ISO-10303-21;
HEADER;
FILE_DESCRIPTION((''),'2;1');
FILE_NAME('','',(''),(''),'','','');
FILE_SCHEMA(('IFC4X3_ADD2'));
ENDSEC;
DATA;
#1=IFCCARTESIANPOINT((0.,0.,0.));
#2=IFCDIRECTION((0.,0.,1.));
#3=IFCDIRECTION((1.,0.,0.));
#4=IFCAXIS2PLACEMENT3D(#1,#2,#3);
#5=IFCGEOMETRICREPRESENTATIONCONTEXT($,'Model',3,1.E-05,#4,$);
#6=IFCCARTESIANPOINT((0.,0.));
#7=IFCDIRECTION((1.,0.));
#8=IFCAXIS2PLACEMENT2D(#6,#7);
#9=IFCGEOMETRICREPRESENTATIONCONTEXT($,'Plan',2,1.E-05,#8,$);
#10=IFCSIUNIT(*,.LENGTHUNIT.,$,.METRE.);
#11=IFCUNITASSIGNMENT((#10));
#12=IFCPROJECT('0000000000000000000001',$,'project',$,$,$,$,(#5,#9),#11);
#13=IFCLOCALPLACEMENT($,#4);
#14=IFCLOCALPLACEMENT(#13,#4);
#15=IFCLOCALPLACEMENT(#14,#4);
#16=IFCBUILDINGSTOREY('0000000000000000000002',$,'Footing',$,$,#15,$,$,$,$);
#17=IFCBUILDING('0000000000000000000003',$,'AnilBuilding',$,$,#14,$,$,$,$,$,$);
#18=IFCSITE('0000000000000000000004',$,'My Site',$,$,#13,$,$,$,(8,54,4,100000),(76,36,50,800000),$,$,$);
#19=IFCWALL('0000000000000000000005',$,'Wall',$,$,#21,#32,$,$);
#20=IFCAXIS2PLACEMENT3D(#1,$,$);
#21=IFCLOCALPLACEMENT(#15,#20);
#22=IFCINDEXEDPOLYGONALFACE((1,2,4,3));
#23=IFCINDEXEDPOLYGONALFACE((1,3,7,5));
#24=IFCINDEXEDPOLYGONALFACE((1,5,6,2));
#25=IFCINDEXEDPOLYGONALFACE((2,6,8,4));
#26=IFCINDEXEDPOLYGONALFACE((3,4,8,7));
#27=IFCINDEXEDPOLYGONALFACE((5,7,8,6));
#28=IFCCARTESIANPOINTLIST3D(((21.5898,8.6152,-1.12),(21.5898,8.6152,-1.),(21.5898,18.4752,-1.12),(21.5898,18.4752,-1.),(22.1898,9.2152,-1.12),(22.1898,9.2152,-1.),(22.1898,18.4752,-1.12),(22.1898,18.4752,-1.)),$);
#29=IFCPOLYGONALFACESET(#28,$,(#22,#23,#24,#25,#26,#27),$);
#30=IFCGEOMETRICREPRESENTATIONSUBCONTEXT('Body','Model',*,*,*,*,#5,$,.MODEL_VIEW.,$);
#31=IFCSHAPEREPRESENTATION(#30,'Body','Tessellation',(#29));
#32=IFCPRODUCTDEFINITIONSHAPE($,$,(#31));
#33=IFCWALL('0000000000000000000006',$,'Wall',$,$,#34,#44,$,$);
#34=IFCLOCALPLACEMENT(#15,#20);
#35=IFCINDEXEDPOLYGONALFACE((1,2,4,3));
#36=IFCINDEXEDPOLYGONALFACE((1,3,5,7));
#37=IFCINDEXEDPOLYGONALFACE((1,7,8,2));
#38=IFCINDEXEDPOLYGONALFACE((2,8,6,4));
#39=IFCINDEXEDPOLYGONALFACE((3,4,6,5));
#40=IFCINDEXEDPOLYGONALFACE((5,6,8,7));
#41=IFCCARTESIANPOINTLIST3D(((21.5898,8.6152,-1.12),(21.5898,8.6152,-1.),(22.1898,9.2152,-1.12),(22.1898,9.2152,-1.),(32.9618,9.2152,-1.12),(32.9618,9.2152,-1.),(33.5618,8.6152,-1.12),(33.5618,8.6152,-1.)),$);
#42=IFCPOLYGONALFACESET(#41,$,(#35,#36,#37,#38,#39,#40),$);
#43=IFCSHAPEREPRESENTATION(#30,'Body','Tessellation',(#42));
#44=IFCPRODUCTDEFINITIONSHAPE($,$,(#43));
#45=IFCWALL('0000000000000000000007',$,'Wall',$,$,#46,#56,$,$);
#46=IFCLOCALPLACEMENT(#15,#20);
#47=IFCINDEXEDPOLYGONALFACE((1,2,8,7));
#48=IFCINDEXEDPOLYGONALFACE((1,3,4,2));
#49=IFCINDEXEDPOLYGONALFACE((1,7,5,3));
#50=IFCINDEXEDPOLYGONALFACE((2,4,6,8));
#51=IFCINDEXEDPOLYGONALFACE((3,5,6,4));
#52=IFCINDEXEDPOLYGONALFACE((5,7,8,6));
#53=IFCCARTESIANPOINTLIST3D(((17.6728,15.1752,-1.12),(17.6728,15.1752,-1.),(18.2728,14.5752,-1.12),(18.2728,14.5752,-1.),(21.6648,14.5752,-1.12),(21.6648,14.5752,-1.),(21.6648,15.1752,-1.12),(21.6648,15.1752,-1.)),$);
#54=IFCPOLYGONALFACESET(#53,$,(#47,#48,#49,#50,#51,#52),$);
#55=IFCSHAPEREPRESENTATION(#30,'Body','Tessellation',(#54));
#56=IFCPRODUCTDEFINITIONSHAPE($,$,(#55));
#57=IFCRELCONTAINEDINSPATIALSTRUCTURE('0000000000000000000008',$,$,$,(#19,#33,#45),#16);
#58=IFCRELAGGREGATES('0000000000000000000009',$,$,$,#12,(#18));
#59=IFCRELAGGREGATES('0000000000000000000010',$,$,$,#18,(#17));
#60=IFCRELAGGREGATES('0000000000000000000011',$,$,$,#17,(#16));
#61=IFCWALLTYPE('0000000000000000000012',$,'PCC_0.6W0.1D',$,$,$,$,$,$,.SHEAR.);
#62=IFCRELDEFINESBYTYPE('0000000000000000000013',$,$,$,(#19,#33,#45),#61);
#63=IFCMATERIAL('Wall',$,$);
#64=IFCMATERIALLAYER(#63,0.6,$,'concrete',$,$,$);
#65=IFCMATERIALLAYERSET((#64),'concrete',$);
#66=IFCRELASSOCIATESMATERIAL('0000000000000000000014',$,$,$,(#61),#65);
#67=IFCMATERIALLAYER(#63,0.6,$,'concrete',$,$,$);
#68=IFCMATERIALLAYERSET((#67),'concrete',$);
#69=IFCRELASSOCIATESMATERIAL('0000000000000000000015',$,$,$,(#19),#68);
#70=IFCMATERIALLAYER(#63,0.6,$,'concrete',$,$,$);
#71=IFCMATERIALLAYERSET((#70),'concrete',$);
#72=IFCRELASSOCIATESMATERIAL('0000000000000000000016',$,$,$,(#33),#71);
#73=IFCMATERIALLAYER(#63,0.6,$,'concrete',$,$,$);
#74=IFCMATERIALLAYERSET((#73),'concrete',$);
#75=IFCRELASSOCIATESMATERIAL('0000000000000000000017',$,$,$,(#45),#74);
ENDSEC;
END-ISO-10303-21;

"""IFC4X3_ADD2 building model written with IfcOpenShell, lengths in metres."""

from ifc_helpers import new_model, si_unit, frame, origin_with_axes, origin_2d_with_axis, place, context, subcontext, project, spatial, line, indexed_curve, outline, extrude, material, layer, layer_set, layer_usage, type_object, element, save


model = new_model("IFC4X3_ADD2")

# Units and contexts
model_context = context("Model", 3, precision=1e-05, world=origin_with_axes())
plan_context = context("Plan", 2, precision=1e-05, world=origin_2d_with_axis())
body_context = subcontext(model_context, "Body", "Model", "MODEL_VIEW")
ifc_project = project(units=[si_unit("LENGTHUNIT", "METRE")], contexts=[model_context, plan_context])

# Site, building, storey
site_placement = place(None, origin_with_axes())
site = spatial("IfcSite", under=ifc_project, at=site_placement, Name="My Site", RefLatitude=(8, 54, 4, 100000), RefLongitude=(76, 36, 50, 800000))
building_placement = place(site_placement, origin_with_axes())
building = spatial("IfcBuilding", under=site, at=building_placement, Name="AnilBuilding")
storey_placement = place(building_placement, origin_with_axes())
storey = spatial("IfcBuildingStorey", under=building, at=storey_placement, Name="Footing")

# Walls
ifc_material_1 = material(Name="Wall")
ifc_layer_1 = layer(ifc_material_1, 0.6, Name="concrete")
ifc_layer_set_1 = layer_set([ifc_layer_1], Name="concrete")
wall_type_1 = type_object("IfcWallType", Name="PCC_0.6W0.1D", PredefinedType="SHEAR", material=ifc_layer_set_1)
ifc_layer_2 = layer(ifc_material_1, 0.6, Name="concrete")
ifc_layer_set_2 = layer_set([ifc_layer_2], Name="concrete")
ifc_layer_usage_1 = layer_usage(ifc_layer_set_2, "AXIS2", "POSITIVE", 0.0)
wall_1_placement = place(storey_placement, frame((22.1898, 8.6152, -1.12), z_axis=(0.0, 0.0, 1.0), x_axis=(0.000001, 1.0, 0.0)))
element("IfcWall", 1, at=wall_1_placement, inside=storey, type_object=wall_type_1, material=ifc_layer_usage_1, Name="Wall", context=body_context, shape_type="SweptSolid", body=[
    extrude(outline(indexed_curve([(0.6, 0.0), (0.0, 0.6), (9.86, 0.6), (9.86, 0.0)], segments=[line(1, 2, 3, 4, 1)])), origin_with_axes(), (0.0, 0.0, 1.0), 0.12),
])
ifc_layer_3 = layer(ifc_material_1, 0.6, Name="concrete")
ifc_layer_set_3 = layer_set([ifc_layer_3], Name="concrete")
ifc_layer_usage_2 = layer_usage(ifc_layer_set_3, "AXIS2", "POSITIVE", 0.0)
wall_2_placement = place(storey_placement, frame((22.1898, 8.6152, -1.12), z_axis=(0.0, 0.0, 1.0), x_axis=(1.0, 0.0, 0.0)))
element("IfcWall", 2, at=wall_2_placement, inside=storey, type_object=wall_type_1, material=ifc_layer_usage_2, Name="Wall", context=body_context, shape_type="SweptSolid", body=[
    extrude(outline(indexed_curve([(-0.6, 0.0), (0.0, 0.6), (10.772, 0.6), (11.372, 0.0)], segments=[line(1, 2, 3, 4, 1)])), origin_with_axes(), (0.0, 0.0, 1.0), 0.12),
])
ifc_layer_4 = layer(ifc_material_1, 0.6, Name="concrete")
ifc_layer_set_4 = layer_set([ifc_layer_4], Name="concrete")
ifc_layer_usage_3 = layer_usage(ifc_layer_set_4, "AXIS2", "POSITIVE", 0.0)
wall_3_placement = place(storey_placement, frame((18.2728, 14.5752, -1.12), z_axis=(0.0, 0.0, 1.0), x_axis=(1.0, 0.0, 0.0)))
element("IfcWall", 3, at=wall_3_placement, inside=storey, type_object=wall_type_1, material=ifc_layer_usage_3, Name="Wall", context=body_context, shape_type="SweptSolid", body=[
    extrude(outline(indexed_curve([(0.0, 0.0), (-0.6, 0.6), (3.392, 0.6), (3.392, 0.0)], segments=[line(1, 2, 3, 4, 1)])), origin_with_axes(), (0.0, 0.0, 1.0), 0.12),
])

save(model, "model.ifc")
